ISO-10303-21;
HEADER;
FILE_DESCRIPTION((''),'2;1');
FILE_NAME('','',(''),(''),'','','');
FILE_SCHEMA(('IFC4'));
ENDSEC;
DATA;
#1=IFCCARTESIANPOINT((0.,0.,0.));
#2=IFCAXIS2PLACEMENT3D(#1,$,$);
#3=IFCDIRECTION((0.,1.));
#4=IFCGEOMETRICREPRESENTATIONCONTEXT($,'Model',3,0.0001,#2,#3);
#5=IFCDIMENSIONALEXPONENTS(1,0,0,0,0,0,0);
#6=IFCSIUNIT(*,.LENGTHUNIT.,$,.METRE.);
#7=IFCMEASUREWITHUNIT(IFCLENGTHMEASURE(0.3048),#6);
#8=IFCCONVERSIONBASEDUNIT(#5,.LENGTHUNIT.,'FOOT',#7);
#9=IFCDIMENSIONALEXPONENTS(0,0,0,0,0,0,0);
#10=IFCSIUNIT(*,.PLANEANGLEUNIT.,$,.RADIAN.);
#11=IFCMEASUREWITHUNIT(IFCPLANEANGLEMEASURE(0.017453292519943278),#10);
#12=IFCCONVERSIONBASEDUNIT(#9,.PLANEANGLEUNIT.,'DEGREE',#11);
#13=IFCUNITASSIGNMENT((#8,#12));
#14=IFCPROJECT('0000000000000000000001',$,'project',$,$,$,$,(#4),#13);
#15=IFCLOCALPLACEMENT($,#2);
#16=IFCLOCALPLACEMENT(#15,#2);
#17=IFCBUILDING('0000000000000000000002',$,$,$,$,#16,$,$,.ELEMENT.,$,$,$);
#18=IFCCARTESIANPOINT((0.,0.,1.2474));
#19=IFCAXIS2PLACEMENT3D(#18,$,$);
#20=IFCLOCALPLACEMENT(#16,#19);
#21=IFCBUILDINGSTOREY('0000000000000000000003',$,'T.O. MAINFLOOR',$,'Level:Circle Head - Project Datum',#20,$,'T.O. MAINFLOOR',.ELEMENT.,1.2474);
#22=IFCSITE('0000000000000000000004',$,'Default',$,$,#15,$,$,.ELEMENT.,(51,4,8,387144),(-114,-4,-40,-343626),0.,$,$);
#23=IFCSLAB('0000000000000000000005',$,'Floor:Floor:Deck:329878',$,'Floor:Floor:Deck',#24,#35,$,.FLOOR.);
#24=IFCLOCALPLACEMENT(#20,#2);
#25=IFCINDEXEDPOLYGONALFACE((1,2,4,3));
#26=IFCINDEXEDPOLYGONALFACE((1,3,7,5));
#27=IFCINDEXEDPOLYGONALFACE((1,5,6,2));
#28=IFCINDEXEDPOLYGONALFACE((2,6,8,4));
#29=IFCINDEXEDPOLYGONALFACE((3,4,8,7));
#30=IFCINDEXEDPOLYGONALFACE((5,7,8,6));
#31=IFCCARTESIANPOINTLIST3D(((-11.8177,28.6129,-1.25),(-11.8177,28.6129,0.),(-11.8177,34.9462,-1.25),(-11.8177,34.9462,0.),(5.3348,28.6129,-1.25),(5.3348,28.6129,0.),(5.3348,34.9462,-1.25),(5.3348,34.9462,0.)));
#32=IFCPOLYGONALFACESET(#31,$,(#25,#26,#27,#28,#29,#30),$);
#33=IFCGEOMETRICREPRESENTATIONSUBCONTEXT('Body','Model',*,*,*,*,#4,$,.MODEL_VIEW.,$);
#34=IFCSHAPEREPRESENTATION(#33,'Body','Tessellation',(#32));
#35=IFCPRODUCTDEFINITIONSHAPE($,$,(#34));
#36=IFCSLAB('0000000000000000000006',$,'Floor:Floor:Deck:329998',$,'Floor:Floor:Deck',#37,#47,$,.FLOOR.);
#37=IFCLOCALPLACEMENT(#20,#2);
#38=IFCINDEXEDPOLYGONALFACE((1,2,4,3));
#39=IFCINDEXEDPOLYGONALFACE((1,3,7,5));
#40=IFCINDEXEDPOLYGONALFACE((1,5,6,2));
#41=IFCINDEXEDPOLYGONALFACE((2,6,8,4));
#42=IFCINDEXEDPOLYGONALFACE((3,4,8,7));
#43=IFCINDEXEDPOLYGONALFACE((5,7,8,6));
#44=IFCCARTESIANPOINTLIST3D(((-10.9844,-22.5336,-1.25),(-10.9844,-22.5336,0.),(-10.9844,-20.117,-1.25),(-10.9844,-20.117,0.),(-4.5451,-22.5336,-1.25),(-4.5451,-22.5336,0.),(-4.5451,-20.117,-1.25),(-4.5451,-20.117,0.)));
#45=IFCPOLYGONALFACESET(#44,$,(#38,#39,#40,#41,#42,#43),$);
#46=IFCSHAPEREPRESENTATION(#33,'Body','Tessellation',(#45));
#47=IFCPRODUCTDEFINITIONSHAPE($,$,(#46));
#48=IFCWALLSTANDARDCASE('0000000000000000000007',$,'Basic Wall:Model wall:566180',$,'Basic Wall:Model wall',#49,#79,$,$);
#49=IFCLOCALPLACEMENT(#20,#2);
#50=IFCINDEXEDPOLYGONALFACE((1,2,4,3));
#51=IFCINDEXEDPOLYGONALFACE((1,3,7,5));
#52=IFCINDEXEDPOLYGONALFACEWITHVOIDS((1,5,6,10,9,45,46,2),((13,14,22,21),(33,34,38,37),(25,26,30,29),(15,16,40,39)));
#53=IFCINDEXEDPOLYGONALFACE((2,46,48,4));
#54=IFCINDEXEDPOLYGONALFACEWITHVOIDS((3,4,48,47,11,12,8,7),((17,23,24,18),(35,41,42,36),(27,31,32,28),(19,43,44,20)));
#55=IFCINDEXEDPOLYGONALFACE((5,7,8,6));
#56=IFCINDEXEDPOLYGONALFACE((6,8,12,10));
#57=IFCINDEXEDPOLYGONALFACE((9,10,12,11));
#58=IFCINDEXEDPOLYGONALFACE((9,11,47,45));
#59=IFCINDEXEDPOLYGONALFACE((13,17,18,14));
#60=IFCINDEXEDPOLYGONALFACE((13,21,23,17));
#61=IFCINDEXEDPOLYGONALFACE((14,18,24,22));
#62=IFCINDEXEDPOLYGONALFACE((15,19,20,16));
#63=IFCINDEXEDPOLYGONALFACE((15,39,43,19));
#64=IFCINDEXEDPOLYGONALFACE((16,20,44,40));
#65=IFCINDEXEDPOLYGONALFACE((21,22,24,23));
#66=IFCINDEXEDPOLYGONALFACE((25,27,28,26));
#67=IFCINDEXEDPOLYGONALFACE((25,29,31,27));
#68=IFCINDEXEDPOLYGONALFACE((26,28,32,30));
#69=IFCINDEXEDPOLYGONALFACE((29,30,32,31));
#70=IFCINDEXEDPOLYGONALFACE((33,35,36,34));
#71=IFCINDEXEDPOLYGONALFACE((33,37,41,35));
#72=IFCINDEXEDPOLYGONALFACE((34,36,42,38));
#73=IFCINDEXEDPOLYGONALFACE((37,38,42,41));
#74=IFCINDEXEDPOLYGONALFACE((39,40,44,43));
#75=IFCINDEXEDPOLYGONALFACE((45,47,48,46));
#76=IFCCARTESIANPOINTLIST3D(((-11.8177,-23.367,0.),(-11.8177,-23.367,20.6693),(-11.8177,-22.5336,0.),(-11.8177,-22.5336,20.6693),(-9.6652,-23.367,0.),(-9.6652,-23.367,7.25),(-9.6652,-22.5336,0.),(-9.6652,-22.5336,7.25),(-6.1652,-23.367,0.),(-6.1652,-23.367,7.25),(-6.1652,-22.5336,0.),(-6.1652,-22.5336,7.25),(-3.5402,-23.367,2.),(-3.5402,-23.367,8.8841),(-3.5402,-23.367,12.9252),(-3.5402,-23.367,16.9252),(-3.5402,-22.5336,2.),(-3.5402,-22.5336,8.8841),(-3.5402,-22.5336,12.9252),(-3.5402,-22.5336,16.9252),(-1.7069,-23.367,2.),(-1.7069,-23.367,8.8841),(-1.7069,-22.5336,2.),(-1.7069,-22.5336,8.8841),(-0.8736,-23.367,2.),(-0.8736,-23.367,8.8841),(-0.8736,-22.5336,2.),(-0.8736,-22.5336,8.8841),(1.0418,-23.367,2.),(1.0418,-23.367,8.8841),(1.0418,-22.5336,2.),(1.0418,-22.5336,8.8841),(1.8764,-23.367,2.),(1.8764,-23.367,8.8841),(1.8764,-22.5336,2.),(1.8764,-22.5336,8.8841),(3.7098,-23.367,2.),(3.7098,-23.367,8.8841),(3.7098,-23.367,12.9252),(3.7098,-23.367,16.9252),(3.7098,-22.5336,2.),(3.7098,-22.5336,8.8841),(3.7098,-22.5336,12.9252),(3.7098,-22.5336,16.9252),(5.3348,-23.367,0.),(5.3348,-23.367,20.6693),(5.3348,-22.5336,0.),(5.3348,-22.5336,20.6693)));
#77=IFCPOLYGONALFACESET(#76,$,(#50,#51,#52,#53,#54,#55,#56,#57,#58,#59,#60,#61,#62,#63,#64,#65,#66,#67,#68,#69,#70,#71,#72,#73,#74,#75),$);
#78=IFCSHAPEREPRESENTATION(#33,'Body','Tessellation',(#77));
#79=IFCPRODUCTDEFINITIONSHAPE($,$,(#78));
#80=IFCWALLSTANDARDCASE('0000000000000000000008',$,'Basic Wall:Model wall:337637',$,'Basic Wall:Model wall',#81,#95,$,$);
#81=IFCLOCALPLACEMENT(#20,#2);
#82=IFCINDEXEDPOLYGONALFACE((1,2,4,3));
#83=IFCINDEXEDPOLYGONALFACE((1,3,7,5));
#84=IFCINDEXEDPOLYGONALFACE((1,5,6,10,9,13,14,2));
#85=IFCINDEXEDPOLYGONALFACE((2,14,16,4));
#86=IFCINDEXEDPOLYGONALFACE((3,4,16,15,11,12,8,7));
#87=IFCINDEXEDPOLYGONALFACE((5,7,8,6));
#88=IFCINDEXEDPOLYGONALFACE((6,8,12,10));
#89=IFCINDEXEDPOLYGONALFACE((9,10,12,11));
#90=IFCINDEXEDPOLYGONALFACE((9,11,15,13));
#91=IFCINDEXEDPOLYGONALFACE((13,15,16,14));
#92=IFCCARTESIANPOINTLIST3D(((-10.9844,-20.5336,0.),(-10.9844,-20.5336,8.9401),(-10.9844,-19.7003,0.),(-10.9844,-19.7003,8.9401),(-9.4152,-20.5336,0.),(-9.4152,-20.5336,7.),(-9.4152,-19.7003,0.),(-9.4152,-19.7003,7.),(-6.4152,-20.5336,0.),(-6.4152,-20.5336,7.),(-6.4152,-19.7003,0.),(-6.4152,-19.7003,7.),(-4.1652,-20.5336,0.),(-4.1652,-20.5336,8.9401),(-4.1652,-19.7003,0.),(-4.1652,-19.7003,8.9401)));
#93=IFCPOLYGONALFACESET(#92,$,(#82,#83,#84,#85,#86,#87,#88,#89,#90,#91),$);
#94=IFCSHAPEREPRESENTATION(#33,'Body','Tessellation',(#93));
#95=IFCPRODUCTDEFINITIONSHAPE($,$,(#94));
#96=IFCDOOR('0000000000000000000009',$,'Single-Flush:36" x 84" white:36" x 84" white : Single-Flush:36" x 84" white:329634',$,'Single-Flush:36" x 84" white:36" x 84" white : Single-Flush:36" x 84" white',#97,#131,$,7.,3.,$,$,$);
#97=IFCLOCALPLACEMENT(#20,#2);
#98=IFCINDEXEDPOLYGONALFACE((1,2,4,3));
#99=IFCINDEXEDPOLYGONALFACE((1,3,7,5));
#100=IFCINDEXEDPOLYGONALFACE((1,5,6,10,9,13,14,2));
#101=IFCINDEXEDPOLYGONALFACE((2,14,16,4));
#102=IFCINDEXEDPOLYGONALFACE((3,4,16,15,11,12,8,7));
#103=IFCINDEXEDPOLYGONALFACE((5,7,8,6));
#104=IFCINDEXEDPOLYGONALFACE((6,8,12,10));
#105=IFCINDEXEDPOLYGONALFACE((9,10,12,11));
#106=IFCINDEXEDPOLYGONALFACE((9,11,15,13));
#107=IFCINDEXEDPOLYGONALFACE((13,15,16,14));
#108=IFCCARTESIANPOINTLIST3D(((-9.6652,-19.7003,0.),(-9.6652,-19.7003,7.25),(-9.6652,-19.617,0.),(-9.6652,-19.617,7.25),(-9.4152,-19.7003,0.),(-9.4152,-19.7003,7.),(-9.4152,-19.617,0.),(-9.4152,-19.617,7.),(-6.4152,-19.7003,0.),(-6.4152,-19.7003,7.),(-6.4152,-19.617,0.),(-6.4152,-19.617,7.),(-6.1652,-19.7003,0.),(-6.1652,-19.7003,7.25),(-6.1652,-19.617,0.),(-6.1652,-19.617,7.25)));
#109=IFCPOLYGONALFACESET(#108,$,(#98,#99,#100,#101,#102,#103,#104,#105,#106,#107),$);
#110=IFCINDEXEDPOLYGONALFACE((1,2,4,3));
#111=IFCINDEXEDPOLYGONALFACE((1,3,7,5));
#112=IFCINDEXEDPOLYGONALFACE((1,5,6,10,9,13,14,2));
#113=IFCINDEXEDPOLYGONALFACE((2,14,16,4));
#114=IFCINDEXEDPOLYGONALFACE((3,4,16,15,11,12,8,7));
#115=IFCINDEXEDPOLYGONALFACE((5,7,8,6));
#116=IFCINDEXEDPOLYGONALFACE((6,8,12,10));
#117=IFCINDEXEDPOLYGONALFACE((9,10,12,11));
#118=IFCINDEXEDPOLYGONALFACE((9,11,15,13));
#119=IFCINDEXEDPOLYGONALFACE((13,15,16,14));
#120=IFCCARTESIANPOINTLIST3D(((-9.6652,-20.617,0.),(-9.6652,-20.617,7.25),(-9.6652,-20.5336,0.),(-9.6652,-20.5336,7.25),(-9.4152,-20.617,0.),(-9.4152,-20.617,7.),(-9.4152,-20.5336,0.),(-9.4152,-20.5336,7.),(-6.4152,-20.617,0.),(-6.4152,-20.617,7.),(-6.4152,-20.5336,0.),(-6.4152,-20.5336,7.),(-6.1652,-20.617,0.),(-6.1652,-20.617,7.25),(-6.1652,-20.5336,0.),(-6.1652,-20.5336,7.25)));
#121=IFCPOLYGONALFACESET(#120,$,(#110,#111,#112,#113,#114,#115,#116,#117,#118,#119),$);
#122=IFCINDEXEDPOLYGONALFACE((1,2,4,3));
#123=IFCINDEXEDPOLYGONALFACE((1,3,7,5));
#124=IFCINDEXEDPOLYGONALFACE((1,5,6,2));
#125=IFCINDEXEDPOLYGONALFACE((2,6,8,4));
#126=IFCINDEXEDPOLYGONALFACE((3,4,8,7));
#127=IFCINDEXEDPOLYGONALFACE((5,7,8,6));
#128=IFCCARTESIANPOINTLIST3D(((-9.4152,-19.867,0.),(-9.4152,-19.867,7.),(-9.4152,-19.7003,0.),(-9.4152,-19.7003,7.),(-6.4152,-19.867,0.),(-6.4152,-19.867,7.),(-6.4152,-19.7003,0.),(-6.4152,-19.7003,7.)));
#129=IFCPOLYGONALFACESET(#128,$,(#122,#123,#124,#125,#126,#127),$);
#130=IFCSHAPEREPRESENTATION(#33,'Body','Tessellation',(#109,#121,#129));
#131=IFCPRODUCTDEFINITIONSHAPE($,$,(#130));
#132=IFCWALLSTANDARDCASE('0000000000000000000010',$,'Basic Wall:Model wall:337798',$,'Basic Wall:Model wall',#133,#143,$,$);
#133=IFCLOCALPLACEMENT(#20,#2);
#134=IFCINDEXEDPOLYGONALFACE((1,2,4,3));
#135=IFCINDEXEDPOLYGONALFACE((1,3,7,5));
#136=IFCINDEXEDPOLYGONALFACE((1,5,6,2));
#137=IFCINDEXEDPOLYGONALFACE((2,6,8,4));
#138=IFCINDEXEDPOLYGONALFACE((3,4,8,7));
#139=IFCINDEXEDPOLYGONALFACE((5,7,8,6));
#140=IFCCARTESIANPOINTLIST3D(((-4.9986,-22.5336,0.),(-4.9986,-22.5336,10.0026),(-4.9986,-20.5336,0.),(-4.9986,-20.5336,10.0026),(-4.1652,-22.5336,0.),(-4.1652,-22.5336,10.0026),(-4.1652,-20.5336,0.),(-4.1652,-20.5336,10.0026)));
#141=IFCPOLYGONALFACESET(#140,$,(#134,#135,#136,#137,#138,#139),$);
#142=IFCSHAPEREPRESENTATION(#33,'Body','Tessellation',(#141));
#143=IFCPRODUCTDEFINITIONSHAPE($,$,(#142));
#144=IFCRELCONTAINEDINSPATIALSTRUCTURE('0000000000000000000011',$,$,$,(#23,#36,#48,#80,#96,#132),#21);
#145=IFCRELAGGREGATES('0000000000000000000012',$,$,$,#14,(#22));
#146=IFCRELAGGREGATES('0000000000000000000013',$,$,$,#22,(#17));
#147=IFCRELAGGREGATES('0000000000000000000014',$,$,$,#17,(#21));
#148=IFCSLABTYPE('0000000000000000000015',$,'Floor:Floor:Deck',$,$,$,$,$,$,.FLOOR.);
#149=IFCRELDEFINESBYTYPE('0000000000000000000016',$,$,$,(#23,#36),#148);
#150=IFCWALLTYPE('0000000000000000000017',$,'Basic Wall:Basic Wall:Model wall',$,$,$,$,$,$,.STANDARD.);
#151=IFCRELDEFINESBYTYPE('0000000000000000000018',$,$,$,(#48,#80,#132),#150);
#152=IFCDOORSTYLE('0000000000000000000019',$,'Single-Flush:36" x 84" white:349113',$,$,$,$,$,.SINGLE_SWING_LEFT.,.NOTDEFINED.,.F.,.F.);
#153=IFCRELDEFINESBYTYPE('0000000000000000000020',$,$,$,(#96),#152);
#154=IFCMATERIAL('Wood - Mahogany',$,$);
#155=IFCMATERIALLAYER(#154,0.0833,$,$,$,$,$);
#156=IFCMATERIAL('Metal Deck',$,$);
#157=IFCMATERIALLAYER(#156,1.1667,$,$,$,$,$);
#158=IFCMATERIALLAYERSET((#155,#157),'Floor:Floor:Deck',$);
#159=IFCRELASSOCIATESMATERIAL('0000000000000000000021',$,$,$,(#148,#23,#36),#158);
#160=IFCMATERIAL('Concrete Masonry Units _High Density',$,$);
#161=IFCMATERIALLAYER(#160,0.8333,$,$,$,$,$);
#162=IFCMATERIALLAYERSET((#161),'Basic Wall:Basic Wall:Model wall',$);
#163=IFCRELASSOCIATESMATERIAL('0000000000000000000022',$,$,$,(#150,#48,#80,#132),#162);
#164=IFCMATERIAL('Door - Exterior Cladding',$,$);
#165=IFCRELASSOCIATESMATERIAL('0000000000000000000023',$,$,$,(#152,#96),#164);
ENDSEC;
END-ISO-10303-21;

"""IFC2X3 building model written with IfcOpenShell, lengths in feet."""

from ifc_helpers import new_model, entity, si_unit, converted_unit, direction, frame, frame_2d, origin, origin_2d_with_axis, place, context, subcontext, project, spatial, polyline, rectangle, outline, extrude, source, transform, mapped, material, layer, layer_set, layer_usage, type_object, type_shapes, element, fill, save


model = new_model("IFC2X3")

# Units and contexts
model_context = context("Model", 3, precision=0.0001, world=origin(), true_north=direction((0.0, 1.0)))
body_context = subcontext(model_context, "Body", "Model", "MODEL_VIEW")
ifc_project = project(units=[converted_unit("LENGTHUNIT", "FOOT", entity("IfcLengthMeasure", 0.3048), si_unit("LENGTHUNIT", "METRE"), dimensions=[1, 0, 0, 0, 0, 0, 0]), converted_unit("PLANEANGLEUNIT", "DEGREE", entity("IfcPlaneAngleMeasure", 0.017453292519943278), si_unit("PLANEANGLEUNIT", "RADIAN"), dimensions=[0, 0, 0, 0, 0, 0, 0])], contexts=[model_context])

# Site, building, storey
site_placement = place(None, origin())
site = spatial("IfcSite", under=ifc_project, at=site_placement, Name="Default", CompositionType="ELEMENT", RefLatitude=(51, 4, 8, 387144), RefLongitude=(-114, -4, -40, -343626), RefElevation=0.0)
building_placement = place(site_placement, origin())
building = spatial("IfcBuilding", under=site, at=building_placement, CompositionType="ELEMENT")
storey_placement = place(building_placement, frame((0.0, 0.0, 1.2474)))
storey = spatial("IfcBuildingStorey", under=building, at=storey_placement, Name="T.O. MAINFLOOR", ObjectType="Level:Circle Head - Project Datum", LongName="T.O. MAINFLOOR", CompositionType="ELEMENT", Elevation=1.2474)

# Slabs
ifc_material_1 = material(Name="Wood - Mahogany")
ifc_layer_1 = layer(ifc_material_1, 0.0833)
ifc_material_2 = material(Name="Metal Deck")
ifc_layer_2 = layer(ifc_material_2, 1.1667)
ifc_layer_set_1 = layer_set([ifc_layer_1, ifc_layer_2], Name="Floor:Floor:Deck")
ifc_layer_usage_1 = layer_usage(ifc_layer_set_1, "AXIS3", "POSITIVE", 0.0)
slab_type_1 = type_object("IfcSlabType", Name="Floor:Floor:Deck", PredefinedType="FLOOR", material=ifc_layer_set_1)
slab_1_placement = place(storey_placement, origin())
element("IfcSlab", 1, at=slab_1_placement, inside=storey, type_object=slab_type_1, material=ifc_layer_usage_1, Name="Floor:Floor:Deck:329878", ObjectType="Floor:Floor:Deck", PredefinedType="FLOOR", context=body_context, shape_type="SweptSolid", body=[
    extrude(rectangle(XDim=6.3333, YDim=17.1525, at=frame_2d((0.0, 0.0), x_axis=(1.0, 0.0))), frame((-3.2415, 31.7795, 0.0), z_axis=(0.0, 0.0, -1.0), x_axis=(0.0, 1.0, 0.0)), (0.0, 0.0, 1.0), 1.25),
])
ifc_layer_usage_2 = layer_usage(ifc_layer_set_1, "AXIS3", "POSITIVE", 0.0)
slab_2_placement = place(storey_placement, origin())
element("IfcSlab", 2, at=slab_2_placement, inside=storey, type_object=slab_type_1, material=ifc_layer_usage_2, Name="Floor:Floor:Deck:329998", ObjectType="Floor:Floor:Deck", PredefinedType="FLOOR", context=body_context, shape_type="SweptSolid", body=[
    extrude(rectangle(XDim=2.4167, YDim=6.4392, at=origin_2d_with_axis()), frame((-7.7648, -21.3253, 0.0), z_axis=(0.0, 0.0, -1.0), x_axis=(0.0, 1.0, 0.0)), (0.0, 0.0, 1.0), 1.25),
])

# Wall, openings
ifc_material_3 = material(Name="Concrete Masonry Units _High Density")
ifc_layer_3 = layer(ifc_material_3, 0.8333)
ifc_layer_set_2 = layer_set([ifc_layer_3], Name="Basic Wall:Basic Wall:Model wall")
ifc_layer_usage_3 = layer_usage(ifc_layer_set_2, "AXIS2", "NEGATIVE", 0.4167)
wall_type_1 = type_object("IfcWallType", Name="Basic Wall:Basic Wall:Model wall", PredefinedType="STANDARD", material=ifc_layer_set_2)
wall_1_placement = place(storey_placement, frame((5.3348, -22.9503, 0.0), z_axis=(0.0, 0.0, 1.0), x_axis=(-1.0, 0.0, 0.0)))
wall_1 = element("IfcWallStandardCase", 3, at=wall_1_placement, inside=storey, type_object=wall_type_1, material=ifc_layer_usage_3, Name="Basic Wall:Model wall:566180", ObjectType="Basic Wall:Model wall", context=body_context, shape_type="SweptSolid", body=[
    extrude(rectangle(XDim=17.1525, YDim=0.8333, at=frame_2d((8.5762, 0.0), x_axis=(-1.0, 0.0))), origin(), (0.0, 0.0, 1.0), 20.6693),
])
opening_1_placement = place(wall_1_placement, origin())
element("IfcOpeningElement", 4, at=opening_1_placement, cuts=wall_1, ObjectType="Opening", context=body_context, shape_type="SweptSolid", body=[
    extrude(rectangle(XDim=4.0, YDim=7.25, at=frame_2d((0.0, 0.0), x_axis=(1.0, 0.0))), frame((5.25, -0.4167, 14.9252), z_axis=(0.0, 1.0, 0.0), x_axis=(0.0, 0.0, -1.0)), (0.0, 0.0, 1.0), 0.8333),
])
opening_2_placement = place(wall_1_placement, origin())
element("IfcOpeningElement", 5, at=opening_2_placement, cuts=wall_1, ObjectType="Opening", context=body_context, shape_type="SweptSolid", body=[
    extrude(rectangle(XDim=6.8841, YDim=1.8333, at=frame_2d((0.0, 0.0), x_axis=(1.0, 0.0))), frame((7.9583, -0.4167, 5.4421), z_axis=(0.0, 1.0, 0.0), x_axis=(0.0, 0.0, -1.0)), (0.0, 0.0, 1.0), 0.8333),
])
opening_3_placement = place(wall_1_placement, origin())
element("IfcOpeningElement", 6, at=opening_3_placement, cuts=wall_1, ObjectType="Opening", context=body_context, shape_type="SweptSolid", body=[
    extrude(rectangle(XDim=6.8841, YDim=1.9154, at=frame_2d((0.0, 0.0), x_axis=(1.0, 0.0))), frame((5.2507, -0.4167, 5.4421), z_axis=(0.0, 1.0, 0.0), x_axis=(0.0, 0.0, -1.0)), (0.0, 0.0, 1.0), 0.8333),
])
opening_4_placement = place(wall_1_placement, origin())
element("IfcOpeningElement", 7, at=opening_4_placement, cuts=wall_1, ObjectType="Opening", context=body_context, shape_type="SweptSolid", body=[
    extrude(rectangle(XDim=6.8841, YDim=1.8333, at=frame_2d((0.0, 0.0), x_axis=(1.0, 0.0))), frame((2.5417, -0.4167, 5.4421), z_axis=(0.0, 1.0, 0.0), x_axis=(0.0, 0.0, -1.0)), (0.0, 0.0, 1.0), 0.8333),
])
opening_5_placement = place(wall_1_placement, origin())
element("IfcOpeningElement", 8, at=opening_5_placement, cuts=wall_1, ObjectType="Opening", context=body_context, shape_type="SweptSolid", body=[
    extrude(rectangle(XDim=7.25, YDim=3.5, at=frame_2d((0.0, 0.0), x_axis=(1.0, 0.0))), frame((13.25, -0.4167, 3.625), z_axis=(0.0, 1.0, 0.0), x_axis=(0.0, 0.0, -1.0)), (0.0, 0.0, 1.0), 0.8333),
])

# Wall, opening, door
ifc_layer_usage_4 = layer_usage(ifc_layer_set_2, "AXIS2", "NEGATIVE", 0.4167)
wall_2_placement = place(storey_placement, frame((-10.9844, -20.117, 0.0)))
wall_2 = element("IfcWallStandardCase", 9, at=wall_2_placement, inside=storey, type_object=wall_type_1, material=ifc_layer_usage_4, Name="Basic Wall:Model wall:337637", ObjectType="Basic Wall:Model wall", context=body_context, shape_type="SweptSolid", body=[
    extrude(rectangle(XDim=6.8192, YDim=0.8333, at=frame_2d((3.4096, 0.0), x_axis=(-1.0, 0.0))), origin(), (0.0, 0.0, 1.0), 8.9401),
])
opening_6_placement = place(wall_2_placement, frame((10.9844, 20.117, 0.0)))
opening_6 = element("IfcOpeningElement", 10, at=opening_6_placement, cuts=wall_2, ObjectType="Opening", context=body_context, shape_type="SweptSolid", body=[
    extrude(rectangle(XDim=7.0, YDim=3.0, at=frame_2d((0.0, 0.0), x_axis=(1.0, 0.0))), frame((-7.9152, -20.542, 3.5), z_axis=(0.0, 1.0, 0.0), x_axis=(0.0, 0.0, 1.0)), (0.0, 0.0, 1.0), 0.85),
])
ifc_material_4 = material(Name="Door - Exterior Cladding")
door_style_1 = type_object("IfcDoorStyle", Name="Single-Flush:36\" x 84\" white:349113", ConstructionType="NOTDEFINED", OperationType="SINGLE_SWING_LEFT", ParameterTakesPrecedence=False, Sizeable=False, material=ifc_material_4)
shared_shape_1 = source(origin(), body_context, "Body", "SweptSolid", [
    extrude(outline(polyline([(-1.75, -3.6875), (1.75, -3.6875), (1.75, 3.5625), (1.5, 3.5625), (1.5, -3.4375), (-1.5, -3.4375), (-1.5, 3.5625), (-1.75, 3.5625), (-1.75, -3.6875)])), frame((1.5, -0.0083, 3.5625), z_axis=(0.0, 1.0, 0.0), x_axis=(1.0, 0.0, 0.0)), (0.0, 0.0, 1.0), 0.0833),
    extrude(outline(polyline([(-3.5625, -1.75), (3.6875, -1.75), (3.6875, 1.75), (-3.5625, 1.75), (-3.5625, 1.5), (3.4375, 1.5), (3.4375, -1.5), (-3.5625, -1.5), (-3.5625, -1.75)])), frame((1.5, -0.925, 3.5625), z_axis=(0.0, 1.0, 0.0), x_axis=(0.0, 0.0, 1.0)), (0.0, 0.0, 1.0), 0.0833),
    extrude(rectangle(XDim=0.1667, YDim=3.0, at=origin_2d_with_axis()), frame((1.5, -0.0917, 0.0), z_axis=(0.0, 0.0, 1.0), x_axis=(0.0, 1.0, 0.0)), (0.0, 0.0, 1.0), 7.0),
])
type_shapes(door_style_1, [shared_shape_1])
door_1_placement = place(opening_6_placement, frame((-9.4152, -19.692, 0.0)))
door_1 = element("IfcDoor", 11, at=door_1_placement, inside=storey, type_object=door_style_1, material=ifc_material_4, Name="Single-Flush:36\" x 84\" white:36\" x 84\" white : Single-Flush:36\" x 84\" white:329634", ObjectType="Single-Flush:36\" x 84\" white:36\" x 84\" white : Single-Flush:36\" x 84\" white", OverallHeight=7.0, OverallWidth=3.0, context=body_context, shape_type="MappedRepresentation", body=[
    mapped(shared_shape_1, transform((0.0, 0.0, 0.0), scale=1.0)),
])
fill(opening_6, door_1)

# Wall
ifc_layer_usage_5 = layer_usage(ifc_layer_set_2, "AXIS2", "NEGATIVE", 0.4167)
wall_3_placement = place(storey_placement, frame((-4.5819, -20.5336, 0.0), z_axis=(0.0, 0.0, 1.0), x_axis=(0.0, -1.0, 0.0)))
element("IfcWallStandardCase", 12, at=wall_3_placement, inside=storey, type_object=wall_type_1, material=ifc_layer_usage_5, Name="Basic Wall:Model wall:337798", ObjectType="Basic Wall:Model wall", context=body_context, shape_type="SweptSolid", body=[
    extrude(rectangle(XDim=2.0, YDim=0.8333, at=frame_2d((1.0, 0.0), x_axis=(-1.0, 0.0))), origin(), (0.0, 0.0, 1.0), 10.0026),
])

save(model, "model.ifc")
